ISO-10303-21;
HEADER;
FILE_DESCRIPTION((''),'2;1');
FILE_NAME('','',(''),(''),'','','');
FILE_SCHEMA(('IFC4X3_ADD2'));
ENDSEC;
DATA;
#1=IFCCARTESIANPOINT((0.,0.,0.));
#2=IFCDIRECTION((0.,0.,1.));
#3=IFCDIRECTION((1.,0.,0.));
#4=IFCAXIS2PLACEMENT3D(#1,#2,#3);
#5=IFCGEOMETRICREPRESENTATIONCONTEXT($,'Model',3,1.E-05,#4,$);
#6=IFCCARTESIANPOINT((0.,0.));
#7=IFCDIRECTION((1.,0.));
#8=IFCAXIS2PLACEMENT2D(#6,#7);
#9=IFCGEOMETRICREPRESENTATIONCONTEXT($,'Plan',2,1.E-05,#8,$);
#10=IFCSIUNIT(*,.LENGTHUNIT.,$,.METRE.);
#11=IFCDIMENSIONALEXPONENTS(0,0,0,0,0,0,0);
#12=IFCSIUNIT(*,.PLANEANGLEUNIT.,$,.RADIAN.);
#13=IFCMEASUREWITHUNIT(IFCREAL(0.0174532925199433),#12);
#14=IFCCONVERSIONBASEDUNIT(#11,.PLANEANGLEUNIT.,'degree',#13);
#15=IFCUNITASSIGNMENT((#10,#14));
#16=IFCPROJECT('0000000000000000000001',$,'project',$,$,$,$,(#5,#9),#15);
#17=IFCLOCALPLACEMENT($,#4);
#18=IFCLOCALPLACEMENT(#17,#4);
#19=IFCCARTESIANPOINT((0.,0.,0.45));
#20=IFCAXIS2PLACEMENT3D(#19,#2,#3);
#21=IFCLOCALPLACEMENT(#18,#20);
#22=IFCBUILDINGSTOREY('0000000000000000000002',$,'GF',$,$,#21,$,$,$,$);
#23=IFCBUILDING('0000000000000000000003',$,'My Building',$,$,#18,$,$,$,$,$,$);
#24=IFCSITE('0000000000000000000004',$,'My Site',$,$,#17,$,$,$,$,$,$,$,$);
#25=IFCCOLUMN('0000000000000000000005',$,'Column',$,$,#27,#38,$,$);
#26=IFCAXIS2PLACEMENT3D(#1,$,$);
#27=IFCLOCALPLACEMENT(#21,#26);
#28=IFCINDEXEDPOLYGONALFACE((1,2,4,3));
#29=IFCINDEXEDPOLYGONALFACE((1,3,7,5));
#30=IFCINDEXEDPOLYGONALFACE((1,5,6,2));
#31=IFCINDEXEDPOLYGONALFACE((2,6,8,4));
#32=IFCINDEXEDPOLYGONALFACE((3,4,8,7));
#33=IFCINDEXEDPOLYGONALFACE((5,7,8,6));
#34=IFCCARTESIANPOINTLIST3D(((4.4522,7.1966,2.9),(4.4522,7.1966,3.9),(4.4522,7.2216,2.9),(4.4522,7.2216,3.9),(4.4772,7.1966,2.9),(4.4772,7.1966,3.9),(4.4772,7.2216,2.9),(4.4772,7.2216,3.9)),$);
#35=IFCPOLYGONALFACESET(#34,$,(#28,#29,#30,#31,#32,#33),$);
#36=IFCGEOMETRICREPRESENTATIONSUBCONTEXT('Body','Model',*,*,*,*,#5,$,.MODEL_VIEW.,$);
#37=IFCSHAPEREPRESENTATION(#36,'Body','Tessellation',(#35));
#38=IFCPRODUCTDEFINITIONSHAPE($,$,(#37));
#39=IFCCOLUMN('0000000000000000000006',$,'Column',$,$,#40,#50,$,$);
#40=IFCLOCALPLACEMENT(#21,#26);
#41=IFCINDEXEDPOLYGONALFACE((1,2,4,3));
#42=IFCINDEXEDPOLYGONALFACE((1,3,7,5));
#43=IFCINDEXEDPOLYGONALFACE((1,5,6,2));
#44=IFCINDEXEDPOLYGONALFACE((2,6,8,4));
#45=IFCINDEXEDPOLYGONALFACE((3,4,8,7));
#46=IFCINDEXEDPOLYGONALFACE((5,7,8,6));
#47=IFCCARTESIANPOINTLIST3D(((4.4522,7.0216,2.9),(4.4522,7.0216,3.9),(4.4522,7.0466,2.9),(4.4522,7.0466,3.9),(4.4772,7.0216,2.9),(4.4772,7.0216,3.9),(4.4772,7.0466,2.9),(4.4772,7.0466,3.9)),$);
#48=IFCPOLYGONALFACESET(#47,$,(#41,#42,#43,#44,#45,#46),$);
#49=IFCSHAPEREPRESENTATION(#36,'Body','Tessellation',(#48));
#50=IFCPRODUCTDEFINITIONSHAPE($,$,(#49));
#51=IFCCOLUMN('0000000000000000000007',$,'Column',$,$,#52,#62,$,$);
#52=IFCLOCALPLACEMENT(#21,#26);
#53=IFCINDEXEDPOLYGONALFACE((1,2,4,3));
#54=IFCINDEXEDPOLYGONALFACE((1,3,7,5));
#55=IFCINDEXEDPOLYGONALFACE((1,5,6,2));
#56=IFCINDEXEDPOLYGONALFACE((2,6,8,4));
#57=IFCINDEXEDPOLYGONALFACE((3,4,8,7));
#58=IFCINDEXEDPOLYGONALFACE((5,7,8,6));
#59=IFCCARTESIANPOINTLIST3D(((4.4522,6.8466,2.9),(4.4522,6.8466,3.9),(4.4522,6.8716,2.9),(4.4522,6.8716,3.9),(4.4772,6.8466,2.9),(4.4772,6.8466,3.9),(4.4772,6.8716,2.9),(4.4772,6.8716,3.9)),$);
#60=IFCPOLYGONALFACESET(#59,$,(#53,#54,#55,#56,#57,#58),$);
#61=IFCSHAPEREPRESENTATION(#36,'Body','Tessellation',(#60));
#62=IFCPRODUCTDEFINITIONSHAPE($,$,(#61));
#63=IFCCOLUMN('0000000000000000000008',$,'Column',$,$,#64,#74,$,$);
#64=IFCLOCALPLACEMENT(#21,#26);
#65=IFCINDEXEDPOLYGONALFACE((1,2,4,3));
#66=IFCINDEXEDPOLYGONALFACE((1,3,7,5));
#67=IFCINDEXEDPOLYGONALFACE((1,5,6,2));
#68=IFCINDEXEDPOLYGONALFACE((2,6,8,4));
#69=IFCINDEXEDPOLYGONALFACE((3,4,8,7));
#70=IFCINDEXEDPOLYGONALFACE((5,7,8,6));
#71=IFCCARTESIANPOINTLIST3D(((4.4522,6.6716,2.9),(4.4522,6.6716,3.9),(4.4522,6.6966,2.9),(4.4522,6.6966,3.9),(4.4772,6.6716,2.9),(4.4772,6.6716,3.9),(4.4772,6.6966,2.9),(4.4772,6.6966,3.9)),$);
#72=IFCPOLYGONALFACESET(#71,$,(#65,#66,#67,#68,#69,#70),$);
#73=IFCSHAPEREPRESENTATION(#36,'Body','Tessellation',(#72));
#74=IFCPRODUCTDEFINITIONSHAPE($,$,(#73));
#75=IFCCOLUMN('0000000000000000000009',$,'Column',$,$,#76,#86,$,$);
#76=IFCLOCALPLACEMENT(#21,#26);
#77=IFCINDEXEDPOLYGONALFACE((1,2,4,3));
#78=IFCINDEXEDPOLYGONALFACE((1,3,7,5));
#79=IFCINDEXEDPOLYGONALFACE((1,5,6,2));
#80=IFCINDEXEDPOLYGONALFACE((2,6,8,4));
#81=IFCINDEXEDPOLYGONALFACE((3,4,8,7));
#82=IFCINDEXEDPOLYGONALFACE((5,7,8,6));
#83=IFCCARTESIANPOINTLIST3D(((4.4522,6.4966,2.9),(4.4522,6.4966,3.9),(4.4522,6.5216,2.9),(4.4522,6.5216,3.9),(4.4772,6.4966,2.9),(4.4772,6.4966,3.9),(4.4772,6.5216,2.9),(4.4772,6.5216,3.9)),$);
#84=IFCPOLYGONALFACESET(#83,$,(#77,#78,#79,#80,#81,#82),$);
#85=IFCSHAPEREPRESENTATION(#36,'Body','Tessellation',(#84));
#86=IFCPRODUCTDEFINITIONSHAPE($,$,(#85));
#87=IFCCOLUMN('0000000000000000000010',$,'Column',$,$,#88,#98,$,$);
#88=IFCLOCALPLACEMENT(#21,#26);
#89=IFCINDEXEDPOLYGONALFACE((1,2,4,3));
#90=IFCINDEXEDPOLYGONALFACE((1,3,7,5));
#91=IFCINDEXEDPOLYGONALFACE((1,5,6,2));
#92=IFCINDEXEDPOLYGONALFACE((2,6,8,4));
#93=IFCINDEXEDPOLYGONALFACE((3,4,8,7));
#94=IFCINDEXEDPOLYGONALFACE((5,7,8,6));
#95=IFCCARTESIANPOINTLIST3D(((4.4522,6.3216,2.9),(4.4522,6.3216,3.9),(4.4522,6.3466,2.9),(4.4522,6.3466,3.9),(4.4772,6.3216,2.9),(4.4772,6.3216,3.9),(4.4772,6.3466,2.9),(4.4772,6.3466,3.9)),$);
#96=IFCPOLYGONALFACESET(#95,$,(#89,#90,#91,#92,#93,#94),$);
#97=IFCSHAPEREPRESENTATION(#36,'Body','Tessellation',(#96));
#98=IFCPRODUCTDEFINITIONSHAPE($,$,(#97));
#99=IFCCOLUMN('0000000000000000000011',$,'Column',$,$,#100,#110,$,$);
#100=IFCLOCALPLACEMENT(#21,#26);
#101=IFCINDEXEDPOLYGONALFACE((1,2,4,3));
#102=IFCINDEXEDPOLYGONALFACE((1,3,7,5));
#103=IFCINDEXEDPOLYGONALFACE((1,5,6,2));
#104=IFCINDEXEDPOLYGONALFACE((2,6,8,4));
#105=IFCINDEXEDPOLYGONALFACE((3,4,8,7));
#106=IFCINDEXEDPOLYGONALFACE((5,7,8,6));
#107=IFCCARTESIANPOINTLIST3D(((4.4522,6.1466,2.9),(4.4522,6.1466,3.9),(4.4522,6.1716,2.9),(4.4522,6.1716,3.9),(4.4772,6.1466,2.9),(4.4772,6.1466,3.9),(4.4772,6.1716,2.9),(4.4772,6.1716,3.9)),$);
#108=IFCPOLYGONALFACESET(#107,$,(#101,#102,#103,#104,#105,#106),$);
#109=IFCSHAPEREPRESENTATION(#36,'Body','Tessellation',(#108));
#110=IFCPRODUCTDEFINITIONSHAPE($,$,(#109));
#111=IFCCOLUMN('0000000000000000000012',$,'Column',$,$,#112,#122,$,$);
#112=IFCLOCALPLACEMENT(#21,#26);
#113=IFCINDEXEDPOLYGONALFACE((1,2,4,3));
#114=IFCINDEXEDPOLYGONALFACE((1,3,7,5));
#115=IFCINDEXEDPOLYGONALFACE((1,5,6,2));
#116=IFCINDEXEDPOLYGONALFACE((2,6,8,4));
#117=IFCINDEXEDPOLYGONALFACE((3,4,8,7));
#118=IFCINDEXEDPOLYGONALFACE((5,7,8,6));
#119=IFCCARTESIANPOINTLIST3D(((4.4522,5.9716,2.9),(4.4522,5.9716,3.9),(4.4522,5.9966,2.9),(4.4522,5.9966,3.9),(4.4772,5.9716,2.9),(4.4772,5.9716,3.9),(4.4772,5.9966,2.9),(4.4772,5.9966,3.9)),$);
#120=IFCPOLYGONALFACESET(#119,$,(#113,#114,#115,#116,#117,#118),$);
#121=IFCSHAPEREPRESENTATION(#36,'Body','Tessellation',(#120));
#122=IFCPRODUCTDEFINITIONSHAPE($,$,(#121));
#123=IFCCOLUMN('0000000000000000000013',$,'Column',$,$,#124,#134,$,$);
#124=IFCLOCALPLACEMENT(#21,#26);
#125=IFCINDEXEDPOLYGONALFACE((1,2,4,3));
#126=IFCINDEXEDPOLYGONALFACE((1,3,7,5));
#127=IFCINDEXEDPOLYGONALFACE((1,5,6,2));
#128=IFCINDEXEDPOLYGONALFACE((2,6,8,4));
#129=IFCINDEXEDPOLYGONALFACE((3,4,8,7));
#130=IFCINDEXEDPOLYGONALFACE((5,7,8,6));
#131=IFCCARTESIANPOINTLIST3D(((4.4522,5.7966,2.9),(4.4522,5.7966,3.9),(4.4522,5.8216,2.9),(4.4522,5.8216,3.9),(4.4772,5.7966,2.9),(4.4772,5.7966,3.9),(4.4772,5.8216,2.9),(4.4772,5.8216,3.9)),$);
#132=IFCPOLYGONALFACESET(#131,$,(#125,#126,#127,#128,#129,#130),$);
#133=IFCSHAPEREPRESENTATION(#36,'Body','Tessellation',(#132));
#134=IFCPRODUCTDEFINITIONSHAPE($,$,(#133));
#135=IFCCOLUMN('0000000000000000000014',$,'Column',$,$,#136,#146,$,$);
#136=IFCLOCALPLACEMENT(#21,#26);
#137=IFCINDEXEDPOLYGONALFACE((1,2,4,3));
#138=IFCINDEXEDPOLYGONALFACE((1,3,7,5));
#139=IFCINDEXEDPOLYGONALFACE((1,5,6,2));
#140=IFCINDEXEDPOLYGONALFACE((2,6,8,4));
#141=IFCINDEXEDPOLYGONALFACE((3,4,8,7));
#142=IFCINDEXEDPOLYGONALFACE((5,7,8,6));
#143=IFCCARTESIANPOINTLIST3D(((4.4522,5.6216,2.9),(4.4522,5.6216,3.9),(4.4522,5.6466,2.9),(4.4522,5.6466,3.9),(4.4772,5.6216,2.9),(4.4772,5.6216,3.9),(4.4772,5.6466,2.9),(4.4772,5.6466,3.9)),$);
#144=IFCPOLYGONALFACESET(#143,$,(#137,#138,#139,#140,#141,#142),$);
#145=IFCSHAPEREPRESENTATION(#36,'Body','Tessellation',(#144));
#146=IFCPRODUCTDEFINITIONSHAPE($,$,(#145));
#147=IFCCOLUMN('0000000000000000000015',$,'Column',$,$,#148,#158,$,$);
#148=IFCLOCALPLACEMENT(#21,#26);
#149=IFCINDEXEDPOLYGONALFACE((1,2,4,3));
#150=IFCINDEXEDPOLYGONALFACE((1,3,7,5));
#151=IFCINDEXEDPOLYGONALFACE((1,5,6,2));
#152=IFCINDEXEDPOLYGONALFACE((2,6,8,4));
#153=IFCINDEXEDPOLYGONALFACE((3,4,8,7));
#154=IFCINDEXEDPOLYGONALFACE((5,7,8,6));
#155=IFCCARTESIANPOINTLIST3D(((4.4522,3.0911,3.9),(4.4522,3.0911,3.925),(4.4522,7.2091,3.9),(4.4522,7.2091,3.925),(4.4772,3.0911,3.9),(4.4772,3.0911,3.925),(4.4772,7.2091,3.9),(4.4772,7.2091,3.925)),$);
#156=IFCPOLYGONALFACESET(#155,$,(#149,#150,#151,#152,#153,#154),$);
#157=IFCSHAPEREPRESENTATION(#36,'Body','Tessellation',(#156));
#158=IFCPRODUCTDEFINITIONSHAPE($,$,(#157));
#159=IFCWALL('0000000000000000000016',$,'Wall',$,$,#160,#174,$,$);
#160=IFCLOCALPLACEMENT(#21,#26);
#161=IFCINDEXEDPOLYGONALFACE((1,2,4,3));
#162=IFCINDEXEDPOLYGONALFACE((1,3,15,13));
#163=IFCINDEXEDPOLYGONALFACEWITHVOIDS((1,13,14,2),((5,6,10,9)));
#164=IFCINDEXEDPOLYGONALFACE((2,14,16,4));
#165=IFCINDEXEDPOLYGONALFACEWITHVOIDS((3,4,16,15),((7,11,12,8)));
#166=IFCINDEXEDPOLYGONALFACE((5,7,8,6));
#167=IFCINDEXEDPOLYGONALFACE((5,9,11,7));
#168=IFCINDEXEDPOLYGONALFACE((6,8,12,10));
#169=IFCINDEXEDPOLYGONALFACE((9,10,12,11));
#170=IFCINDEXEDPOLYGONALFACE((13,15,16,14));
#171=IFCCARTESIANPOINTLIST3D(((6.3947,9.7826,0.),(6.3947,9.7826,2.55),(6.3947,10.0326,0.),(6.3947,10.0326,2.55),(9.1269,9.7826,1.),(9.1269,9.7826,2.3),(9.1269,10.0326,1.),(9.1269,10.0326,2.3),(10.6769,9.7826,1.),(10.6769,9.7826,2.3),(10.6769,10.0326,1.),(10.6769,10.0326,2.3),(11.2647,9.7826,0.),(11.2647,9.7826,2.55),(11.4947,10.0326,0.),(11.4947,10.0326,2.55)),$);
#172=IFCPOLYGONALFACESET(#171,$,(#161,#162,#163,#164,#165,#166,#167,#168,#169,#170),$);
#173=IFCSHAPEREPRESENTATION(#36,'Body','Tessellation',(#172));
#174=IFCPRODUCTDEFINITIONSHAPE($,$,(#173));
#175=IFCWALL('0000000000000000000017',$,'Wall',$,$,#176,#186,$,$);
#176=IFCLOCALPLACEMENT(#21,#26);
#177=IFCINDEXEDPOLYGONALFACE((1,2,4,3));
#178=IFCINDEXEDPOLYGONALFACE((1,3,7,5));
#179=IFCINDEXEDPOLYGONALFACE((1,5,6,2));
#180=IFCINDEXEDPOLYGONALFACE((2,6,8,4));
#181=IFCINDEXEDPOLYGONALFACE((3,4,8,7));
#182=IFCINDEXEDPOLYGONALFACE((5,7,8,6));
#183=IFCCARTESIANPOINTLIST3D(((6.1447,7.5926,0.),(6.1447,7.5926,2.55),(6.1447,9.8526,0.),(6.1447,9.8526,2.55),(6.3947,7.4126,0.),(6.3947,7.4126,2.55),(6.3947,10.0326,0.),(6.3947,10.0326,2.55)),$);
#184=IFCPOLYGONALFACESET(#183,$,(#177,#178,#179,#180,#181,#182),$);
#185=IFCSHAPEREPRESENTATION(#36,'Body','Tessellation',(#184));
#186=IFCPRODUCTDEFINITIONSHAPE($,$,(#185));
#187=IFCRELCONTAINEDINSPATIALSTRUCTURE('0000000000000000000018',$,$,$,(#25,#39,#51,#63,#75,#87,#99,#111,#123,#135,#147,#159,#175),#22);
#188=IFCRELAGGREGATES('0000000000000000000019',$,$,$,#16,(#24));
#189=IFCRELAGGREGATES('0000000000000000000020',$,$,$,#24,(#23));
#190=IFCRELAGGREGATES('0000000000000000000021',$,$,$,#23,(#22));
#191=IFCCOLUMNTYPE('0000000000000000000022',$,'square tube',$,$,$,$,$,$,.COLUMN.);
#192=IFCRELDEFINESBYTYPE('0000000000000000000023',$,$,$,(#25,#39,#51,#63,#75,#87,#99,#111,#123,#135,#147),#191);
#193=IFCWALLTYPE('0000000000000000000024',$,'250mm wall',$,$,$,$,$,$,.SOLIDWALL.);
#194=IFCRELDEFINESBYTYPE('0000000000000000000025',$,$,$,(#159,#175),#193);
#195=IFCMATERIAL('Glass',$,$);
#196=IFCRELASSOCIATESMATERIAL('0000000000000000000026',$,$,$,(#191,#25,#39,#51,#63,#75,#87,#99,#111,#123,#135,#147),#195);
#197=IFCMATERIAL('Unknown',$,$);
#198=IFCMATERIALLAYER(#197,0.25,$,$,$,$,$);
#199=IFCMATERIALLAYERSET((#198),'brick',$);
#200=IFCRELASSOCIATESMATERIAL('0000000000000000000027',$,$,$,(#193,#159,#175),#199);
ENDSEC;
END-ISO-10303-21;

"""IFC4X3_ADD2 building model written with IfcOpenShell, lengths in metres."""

from ifc_helpers import new_model, entity, si_unit, converted_unit, frame, origin_with_axes, origin_2d_with_axis, place, context, subcontext, project, spatial, line, indexed_curve, rectangle, outline, extrude, source, transform, mapped, material, layer, layer_set, layer_usage, material_profile, profile_set, profile_usage, type_object, element, save


model = new_model("IFC4X3_ADD2")

# Units and contexts
model_context = context("Model", 3, precision=1e-05, world=origin_with_axes())
plan_context = context("Plan", 2, precision=1e-05, world=origin_2d_with_axis())
body_context_1 = subcontext(model_context, "Body", "Model", "MODEL_VIEW")
ifc_project = project(units=[si_unit("LENGTHUNIT", "METRE"), converted_unit("PLANEANGLEUNIT", "degree", entity("IfcReal", 0.0174532925199433), si_unit("PLANEANGLEUNIT", "RADIAN"), dimensions=[0, 0, 0, 0, 0, 0, 0])], contexts=[model_context, plan_context])

# Site, building, storey
site_placement = place(None, origin_with_axes())
site = spatial("IfcSite", under=ifc_project, at=site_placement, Name="My Site")
building_placement = place(site_placement, origin_with_axes())
building = spatial("IfcBuilding", under=site, at=building_placement, Name="My Building")
storey_placement = place(building_placement, frame((0.0, 0.0, 0.45), z_axis=(0.0, 0.0, 1.0), x_axis=(1.0, 0.0, 0.0)))
storey = spatial("IfcBuildingStorey", under=building, at=storey_placement, Name="GF")

# Columns
ifc_material_1 = material(Name="Glass")
ifc_material_profile = material_profile(ifc_material_1, rectangle(XDim=0.025, YDim=0.025))
ifc_profile_set = profile_set([ifc_material_profile])
ifc_profile_usage_1 = profile_usage(ifc_profile_set, cardinal=5)
column_type = type_object("IfcColumnType", Name="square tube", PredefinedType="COLUMN", material=ifc_profile_set)
column_1_placement = place(storey_placement, frame((4.4647, 7.2091, 2.9), z_axis=(0.0, 0.0, 1.0), x_axis=(0.0, -1.0, 0.0)))
element("IfcColumn", 1, at=column_1_placement, inside=storey, type_object=column_type, material=ifc_profile_usage_1, Name="Column", context=body_context_1, shape_type="SweptSolid", body=[
    extrude(rectangle(XDim=0.025, YDim=0.025), origin_with_axes(), (0.0, 0.0, 1.0), 1.0),
])
ifc_profile_usage_2 = profile_usage(ifc_profile_set, cardinal=5)
column_2_placement = place(storey_placement, frame((4.4647, 7.0341, 2.9), z_axis=(0.0, 0.0, 1.0), x_axis=(0.0, -1.0, 0.0)))
element("IfcColumn", 2, at=column_2_placement, inside=storey, type_object=column_type, material=ifc_profile_usage_2, Name="Column", context=body_context_1, shape_type="SweptSolid", body=[
    extrude(rectangle(XDim=0.025, YDim=0.025), origin_with_axes(), (0.0, 0.0, 1.0), 1.0),
])
ifc_profile_usage_3 = profile_usage(ifc_profile_set, cardinal=5)
column_3_placement = place(storey_placement, frame((4.4647, 6.8591, 2.9), z_axis=(0.0, 0.0, 1.0), x_axis=(0.0, -1.0, 0.0)))
element("IfcColumn", 3, at=column_3_placement, inside=storey, type_object=column_type, material=ifc_profile_usage_3, Name="Column", context=body_context_1, shape_type="SweptSolid", body=[
    extrude(rectangle(XDim=0.025, YDim=0.025), origin_with_axes(), (0.0, 0.0, 1.0), 1.0),
])
ifc_profile_usage_4 = profile_usage(ifc_profile_set, cardinal=5)
column_4_placement = place(storey_placement, frame((4.4647, 6.6841, 2.9), z_axis=(0.0, 0.0, 1.0), x_axis=(0.0, -1.0, 0.0)))
element("IfcColumn", 4, at=column_4_placement, inside=storey, type_object=column_type, material=ifc_profile_usage_4, Name="Column", context=body_context_1, shape_type="SweptSolid", body=[
    extrude(rectangle(XDim=0.025, YDim=0.025), origin_with_axes(), (0.0, 0.0, 1.0), 1.0),
])
ifc_profile_usage_5 = profile_usage(ifc_profile_set, cardinal=5)
column_5_placement = place(storey_placement, frame((4.4647, 6.5091, 2.9), z_axis=(0.0, 0.0, 1.0), x_axis=(0.0, -1.0, 0.0)))
element("IfcColumn", 5, at=column_5_placement, inside=storey, type_object=column_type, material=ifc_profile_usage_5, Name="Column", context=body_context_1, shape_type="SweptSolid", body=[
    extrude(rectangle(XDim=0.025, YDim=0.025), origin_with_axes(), (0.0, 0.0, 1.0), 1.0),
])
ifc_profile_usage_6 = profile_usage(ifc_profile_set, cardinal=5)
column_6_placement = place(storey_placement, frame((4.4647, 6.3341, 2.9), z_axis=(0.0, 0.0, 1.0), x_axis=(0.0, -1.0, 0.0)))
element("IfcColumn", 6, at=column_6_placement, inside=storey, type_object=column_type, material=ifc_profile_usage_6, Name="Column", context=body_context_1, shape_type="SweptSolid", body=[
    extrude(rectangle(XDim=0.025, YDim=0.025), origin_with_axes(), (0.0, 0.0, 1.0), 1.0),
])
ifc_profile_usage_7 = profile_usage(ifc_profile_set, cardinal=5)
column_7_placement = place(storey_placement, frame((4.4647, 6.1591, 2.9), z_axis=(0.0, 0.0, 1.0), x_axis=(0.0, -1.0, 0.0)))
element("IfcColumn", 7, at=column_7_placement, inside=storey, type_object=column_type, material=ifc_profile_usage_7, Name="Column", context=body_context_1, shape_type="SweptSolid", body=[
    extrude(rectangle(XDim=0.025, YDim=0.025), origin_with_axes(), (0.0, 0.0, 1.0), 1.0),
])
ifc_profile_usage_8 = profile_usage(ifc_profile_set, cardinal=5)
column_8_placement = place(storey_placement, frame((4.4647, 5.9841, 2.9), z_axis=(0.0, 0.0, 1.0), x_axis=(0.0, -1.0, 0.0)))
element("IfcColumn", 8, at=column_8_placement, inside=storey, type_object=column_type, material=ifc_profile_usage_8, Name="Column", context=body_context_1, shape_type="SweptSolid", body=[
    extrude(rectangle(XDim=0.025, YDim=0.025), origin_with_axes(), (0.0, 0.0, 1.0), 1.0),
])
ifc_profile_usage_9 = profile_usage(ifc_profile_set, cardinal=5)
column_9_placement = place(storey_placement, frame((4.4647, 5.8091, 2.9), z_axis=(0.0, 0.0, 1.0), x_axis=(0.0, -1.0, 0.0)))
element("IfcColumn", 9, at=column_9_placement, inside=storey, type_object=column_type, material=ifc_profile_usage_9, Name="Column", context=body_context_1, shape_type="SweptSolid", body=[
    extrude(rectangle(XDim=0.025, YDim=0.025), origin_with_axes(), (0.0, 0.0, 1.0), 1.0),
])
ifc_profile_usage_10 = profile_usage(ifc_profile_set, cardinal=5)
column_10_placement = place(storey_placement, frame((4.4647, 5.6341, 2.9), z_axis=(0.0, 0.0, 1.0), x_axis=(0.0, -1.0, 0.0)))
element("IfcColumn", 10, at=column_10_placement, inside=storey, type_object=column_type, material=ifc_profile_usage_10, Name="Column", context=body_context_1, shape_type="SweptSolid", body=[
    extrude(rectangle(XDim=0.025, YDim=0.025), origin_with_axes(), (0.0, 0.0, 1.0), 1.0),
])
ifc_profile_usage_11 = profile_usage(ifc_profile_set, cardinal=5)
column_11_placement = place(storey_placement, frame((4.4647, 7.2091, 3.9125), z_axis=(0.0, -1.0, 0.0), x_axis=(0.0, 0.0, -1.0)))
element("IfcColumn", 11, at=column_11_placement, inside=storey, type_object=column_type, material=ifc_profile_usage_11, Name="Column", context=body_context_1, shape_type="SweptSolid", body=[
    extrude(rectangle(XDim=0.025, YDim=0.025), origin_with_axes(), (0.0, 0.0, 1.0), 4.118),
])

# Wall, opening
ifc_material_2 = material(Name="Unknown")
ifc_layer_1 = layer(ifc_material_2, 0.25)
ifc_layer_set_1 = layer_set([ifc_layer_1], Name="brick")
ifc_layer_usage_1 = layer_usage(ifc_layer_set_1, "AXIS2", "POSITIVE", 0.0)
wall_type_1 = type_object("IfcWallType", Name="250mm wall", PredefinedType="SOLIDWALL", material=ifc_layer_set_1)
wall_1_placement = place(storey_placement, frame((6.3947, 9.7826, 0.0), z_axis=(0.0, 0.0, 1.0), x_axis=(1.0, 0.0, 0.0)))
wall_1 = element("IfcWall", 12, at=wall_1_placement, inside=storey, type_object=wall_type_1, material=ifc_layer_usage_1, Name="Wall", context=body_context_1, shape_type="SweptSolid", body=[
    extrude(outline(indexed_curve([(0.0, 0.0), (0.0, 0.25), (5.1, 0.25), (4.87, 0.0)], segments=[line(1, 2, 3, 4, 1)])), origin_with_axes(), (0.0, 0.0, 1.0), 2.55),
])
shared_shape_1 = source(origin_with_axes(), body_context_1, "Body", "SweptSolid", [
    extrude(outline(indexed_curve([(0.0, 0.0), (1.55, 0.0), (1.55, 1.3), (0.0, 1.3)], segments=[line(1, 2, 3, 4, 1)])), frame((-0.775, -0.6, 0.0), z_axis=(0.0, -1.0, 0.0), x_axis=(1.0, 0.0, 0.0)), (0.0, 0.0, -1.0), 1.2),
])
opening_1_placement = place(wall_1_placement, frame((3.5072, 0.2257, 1.0), z_axis=(0.0, 0.0, 1.0), x_axis=(-1.0, 0.0, 0.0)))
element("IfcOpeningElement", 13, at=opening_1_placement, cuts=wall_1, PredefinedType="OPENING", context=body_context_1, shape_type="MappedRepresentation", body=[
    mapped(shared_shape_1, transform((0.0, 0.0, 0.0), x_axis=(1.0, 0.0, 0.0), y_axis=(0.0, 1.0, 0.0), z_axis=(0.0, 0.0, 1.0), scale=1.0)),
])

# Wall
ifc_layer_usage_2 = layer_usage(ifc_layer_set_1, "AXIS2", "POSITIVE", 0.0)
wall_2_placement = place(storey_placement, frame((6.3947, 7.5926, 0.0), z_axis=(0.0, 0.0, 1.0), x_axis=(0.0, 1.0, 0.0)))
element("IfcWall", 14, at=wall_2_placement, inside=storey, type_object=wall_type_1, material=ifc_layer_usage_2, Name="Wall", context=body_context_1, shape_type="SweptSolid", body=[
    extrude(outline(indexed_curve([(-0.18, 0.0), (0.0, 0.25), (2.26, 0.25), (2.44, 0.0)], segments=[line(1, 2, 3, 4, 1)])), origin_with_axes(), (0.0, 0.0, 1.0), 2.55),
])

save(model, "model.ifc")
